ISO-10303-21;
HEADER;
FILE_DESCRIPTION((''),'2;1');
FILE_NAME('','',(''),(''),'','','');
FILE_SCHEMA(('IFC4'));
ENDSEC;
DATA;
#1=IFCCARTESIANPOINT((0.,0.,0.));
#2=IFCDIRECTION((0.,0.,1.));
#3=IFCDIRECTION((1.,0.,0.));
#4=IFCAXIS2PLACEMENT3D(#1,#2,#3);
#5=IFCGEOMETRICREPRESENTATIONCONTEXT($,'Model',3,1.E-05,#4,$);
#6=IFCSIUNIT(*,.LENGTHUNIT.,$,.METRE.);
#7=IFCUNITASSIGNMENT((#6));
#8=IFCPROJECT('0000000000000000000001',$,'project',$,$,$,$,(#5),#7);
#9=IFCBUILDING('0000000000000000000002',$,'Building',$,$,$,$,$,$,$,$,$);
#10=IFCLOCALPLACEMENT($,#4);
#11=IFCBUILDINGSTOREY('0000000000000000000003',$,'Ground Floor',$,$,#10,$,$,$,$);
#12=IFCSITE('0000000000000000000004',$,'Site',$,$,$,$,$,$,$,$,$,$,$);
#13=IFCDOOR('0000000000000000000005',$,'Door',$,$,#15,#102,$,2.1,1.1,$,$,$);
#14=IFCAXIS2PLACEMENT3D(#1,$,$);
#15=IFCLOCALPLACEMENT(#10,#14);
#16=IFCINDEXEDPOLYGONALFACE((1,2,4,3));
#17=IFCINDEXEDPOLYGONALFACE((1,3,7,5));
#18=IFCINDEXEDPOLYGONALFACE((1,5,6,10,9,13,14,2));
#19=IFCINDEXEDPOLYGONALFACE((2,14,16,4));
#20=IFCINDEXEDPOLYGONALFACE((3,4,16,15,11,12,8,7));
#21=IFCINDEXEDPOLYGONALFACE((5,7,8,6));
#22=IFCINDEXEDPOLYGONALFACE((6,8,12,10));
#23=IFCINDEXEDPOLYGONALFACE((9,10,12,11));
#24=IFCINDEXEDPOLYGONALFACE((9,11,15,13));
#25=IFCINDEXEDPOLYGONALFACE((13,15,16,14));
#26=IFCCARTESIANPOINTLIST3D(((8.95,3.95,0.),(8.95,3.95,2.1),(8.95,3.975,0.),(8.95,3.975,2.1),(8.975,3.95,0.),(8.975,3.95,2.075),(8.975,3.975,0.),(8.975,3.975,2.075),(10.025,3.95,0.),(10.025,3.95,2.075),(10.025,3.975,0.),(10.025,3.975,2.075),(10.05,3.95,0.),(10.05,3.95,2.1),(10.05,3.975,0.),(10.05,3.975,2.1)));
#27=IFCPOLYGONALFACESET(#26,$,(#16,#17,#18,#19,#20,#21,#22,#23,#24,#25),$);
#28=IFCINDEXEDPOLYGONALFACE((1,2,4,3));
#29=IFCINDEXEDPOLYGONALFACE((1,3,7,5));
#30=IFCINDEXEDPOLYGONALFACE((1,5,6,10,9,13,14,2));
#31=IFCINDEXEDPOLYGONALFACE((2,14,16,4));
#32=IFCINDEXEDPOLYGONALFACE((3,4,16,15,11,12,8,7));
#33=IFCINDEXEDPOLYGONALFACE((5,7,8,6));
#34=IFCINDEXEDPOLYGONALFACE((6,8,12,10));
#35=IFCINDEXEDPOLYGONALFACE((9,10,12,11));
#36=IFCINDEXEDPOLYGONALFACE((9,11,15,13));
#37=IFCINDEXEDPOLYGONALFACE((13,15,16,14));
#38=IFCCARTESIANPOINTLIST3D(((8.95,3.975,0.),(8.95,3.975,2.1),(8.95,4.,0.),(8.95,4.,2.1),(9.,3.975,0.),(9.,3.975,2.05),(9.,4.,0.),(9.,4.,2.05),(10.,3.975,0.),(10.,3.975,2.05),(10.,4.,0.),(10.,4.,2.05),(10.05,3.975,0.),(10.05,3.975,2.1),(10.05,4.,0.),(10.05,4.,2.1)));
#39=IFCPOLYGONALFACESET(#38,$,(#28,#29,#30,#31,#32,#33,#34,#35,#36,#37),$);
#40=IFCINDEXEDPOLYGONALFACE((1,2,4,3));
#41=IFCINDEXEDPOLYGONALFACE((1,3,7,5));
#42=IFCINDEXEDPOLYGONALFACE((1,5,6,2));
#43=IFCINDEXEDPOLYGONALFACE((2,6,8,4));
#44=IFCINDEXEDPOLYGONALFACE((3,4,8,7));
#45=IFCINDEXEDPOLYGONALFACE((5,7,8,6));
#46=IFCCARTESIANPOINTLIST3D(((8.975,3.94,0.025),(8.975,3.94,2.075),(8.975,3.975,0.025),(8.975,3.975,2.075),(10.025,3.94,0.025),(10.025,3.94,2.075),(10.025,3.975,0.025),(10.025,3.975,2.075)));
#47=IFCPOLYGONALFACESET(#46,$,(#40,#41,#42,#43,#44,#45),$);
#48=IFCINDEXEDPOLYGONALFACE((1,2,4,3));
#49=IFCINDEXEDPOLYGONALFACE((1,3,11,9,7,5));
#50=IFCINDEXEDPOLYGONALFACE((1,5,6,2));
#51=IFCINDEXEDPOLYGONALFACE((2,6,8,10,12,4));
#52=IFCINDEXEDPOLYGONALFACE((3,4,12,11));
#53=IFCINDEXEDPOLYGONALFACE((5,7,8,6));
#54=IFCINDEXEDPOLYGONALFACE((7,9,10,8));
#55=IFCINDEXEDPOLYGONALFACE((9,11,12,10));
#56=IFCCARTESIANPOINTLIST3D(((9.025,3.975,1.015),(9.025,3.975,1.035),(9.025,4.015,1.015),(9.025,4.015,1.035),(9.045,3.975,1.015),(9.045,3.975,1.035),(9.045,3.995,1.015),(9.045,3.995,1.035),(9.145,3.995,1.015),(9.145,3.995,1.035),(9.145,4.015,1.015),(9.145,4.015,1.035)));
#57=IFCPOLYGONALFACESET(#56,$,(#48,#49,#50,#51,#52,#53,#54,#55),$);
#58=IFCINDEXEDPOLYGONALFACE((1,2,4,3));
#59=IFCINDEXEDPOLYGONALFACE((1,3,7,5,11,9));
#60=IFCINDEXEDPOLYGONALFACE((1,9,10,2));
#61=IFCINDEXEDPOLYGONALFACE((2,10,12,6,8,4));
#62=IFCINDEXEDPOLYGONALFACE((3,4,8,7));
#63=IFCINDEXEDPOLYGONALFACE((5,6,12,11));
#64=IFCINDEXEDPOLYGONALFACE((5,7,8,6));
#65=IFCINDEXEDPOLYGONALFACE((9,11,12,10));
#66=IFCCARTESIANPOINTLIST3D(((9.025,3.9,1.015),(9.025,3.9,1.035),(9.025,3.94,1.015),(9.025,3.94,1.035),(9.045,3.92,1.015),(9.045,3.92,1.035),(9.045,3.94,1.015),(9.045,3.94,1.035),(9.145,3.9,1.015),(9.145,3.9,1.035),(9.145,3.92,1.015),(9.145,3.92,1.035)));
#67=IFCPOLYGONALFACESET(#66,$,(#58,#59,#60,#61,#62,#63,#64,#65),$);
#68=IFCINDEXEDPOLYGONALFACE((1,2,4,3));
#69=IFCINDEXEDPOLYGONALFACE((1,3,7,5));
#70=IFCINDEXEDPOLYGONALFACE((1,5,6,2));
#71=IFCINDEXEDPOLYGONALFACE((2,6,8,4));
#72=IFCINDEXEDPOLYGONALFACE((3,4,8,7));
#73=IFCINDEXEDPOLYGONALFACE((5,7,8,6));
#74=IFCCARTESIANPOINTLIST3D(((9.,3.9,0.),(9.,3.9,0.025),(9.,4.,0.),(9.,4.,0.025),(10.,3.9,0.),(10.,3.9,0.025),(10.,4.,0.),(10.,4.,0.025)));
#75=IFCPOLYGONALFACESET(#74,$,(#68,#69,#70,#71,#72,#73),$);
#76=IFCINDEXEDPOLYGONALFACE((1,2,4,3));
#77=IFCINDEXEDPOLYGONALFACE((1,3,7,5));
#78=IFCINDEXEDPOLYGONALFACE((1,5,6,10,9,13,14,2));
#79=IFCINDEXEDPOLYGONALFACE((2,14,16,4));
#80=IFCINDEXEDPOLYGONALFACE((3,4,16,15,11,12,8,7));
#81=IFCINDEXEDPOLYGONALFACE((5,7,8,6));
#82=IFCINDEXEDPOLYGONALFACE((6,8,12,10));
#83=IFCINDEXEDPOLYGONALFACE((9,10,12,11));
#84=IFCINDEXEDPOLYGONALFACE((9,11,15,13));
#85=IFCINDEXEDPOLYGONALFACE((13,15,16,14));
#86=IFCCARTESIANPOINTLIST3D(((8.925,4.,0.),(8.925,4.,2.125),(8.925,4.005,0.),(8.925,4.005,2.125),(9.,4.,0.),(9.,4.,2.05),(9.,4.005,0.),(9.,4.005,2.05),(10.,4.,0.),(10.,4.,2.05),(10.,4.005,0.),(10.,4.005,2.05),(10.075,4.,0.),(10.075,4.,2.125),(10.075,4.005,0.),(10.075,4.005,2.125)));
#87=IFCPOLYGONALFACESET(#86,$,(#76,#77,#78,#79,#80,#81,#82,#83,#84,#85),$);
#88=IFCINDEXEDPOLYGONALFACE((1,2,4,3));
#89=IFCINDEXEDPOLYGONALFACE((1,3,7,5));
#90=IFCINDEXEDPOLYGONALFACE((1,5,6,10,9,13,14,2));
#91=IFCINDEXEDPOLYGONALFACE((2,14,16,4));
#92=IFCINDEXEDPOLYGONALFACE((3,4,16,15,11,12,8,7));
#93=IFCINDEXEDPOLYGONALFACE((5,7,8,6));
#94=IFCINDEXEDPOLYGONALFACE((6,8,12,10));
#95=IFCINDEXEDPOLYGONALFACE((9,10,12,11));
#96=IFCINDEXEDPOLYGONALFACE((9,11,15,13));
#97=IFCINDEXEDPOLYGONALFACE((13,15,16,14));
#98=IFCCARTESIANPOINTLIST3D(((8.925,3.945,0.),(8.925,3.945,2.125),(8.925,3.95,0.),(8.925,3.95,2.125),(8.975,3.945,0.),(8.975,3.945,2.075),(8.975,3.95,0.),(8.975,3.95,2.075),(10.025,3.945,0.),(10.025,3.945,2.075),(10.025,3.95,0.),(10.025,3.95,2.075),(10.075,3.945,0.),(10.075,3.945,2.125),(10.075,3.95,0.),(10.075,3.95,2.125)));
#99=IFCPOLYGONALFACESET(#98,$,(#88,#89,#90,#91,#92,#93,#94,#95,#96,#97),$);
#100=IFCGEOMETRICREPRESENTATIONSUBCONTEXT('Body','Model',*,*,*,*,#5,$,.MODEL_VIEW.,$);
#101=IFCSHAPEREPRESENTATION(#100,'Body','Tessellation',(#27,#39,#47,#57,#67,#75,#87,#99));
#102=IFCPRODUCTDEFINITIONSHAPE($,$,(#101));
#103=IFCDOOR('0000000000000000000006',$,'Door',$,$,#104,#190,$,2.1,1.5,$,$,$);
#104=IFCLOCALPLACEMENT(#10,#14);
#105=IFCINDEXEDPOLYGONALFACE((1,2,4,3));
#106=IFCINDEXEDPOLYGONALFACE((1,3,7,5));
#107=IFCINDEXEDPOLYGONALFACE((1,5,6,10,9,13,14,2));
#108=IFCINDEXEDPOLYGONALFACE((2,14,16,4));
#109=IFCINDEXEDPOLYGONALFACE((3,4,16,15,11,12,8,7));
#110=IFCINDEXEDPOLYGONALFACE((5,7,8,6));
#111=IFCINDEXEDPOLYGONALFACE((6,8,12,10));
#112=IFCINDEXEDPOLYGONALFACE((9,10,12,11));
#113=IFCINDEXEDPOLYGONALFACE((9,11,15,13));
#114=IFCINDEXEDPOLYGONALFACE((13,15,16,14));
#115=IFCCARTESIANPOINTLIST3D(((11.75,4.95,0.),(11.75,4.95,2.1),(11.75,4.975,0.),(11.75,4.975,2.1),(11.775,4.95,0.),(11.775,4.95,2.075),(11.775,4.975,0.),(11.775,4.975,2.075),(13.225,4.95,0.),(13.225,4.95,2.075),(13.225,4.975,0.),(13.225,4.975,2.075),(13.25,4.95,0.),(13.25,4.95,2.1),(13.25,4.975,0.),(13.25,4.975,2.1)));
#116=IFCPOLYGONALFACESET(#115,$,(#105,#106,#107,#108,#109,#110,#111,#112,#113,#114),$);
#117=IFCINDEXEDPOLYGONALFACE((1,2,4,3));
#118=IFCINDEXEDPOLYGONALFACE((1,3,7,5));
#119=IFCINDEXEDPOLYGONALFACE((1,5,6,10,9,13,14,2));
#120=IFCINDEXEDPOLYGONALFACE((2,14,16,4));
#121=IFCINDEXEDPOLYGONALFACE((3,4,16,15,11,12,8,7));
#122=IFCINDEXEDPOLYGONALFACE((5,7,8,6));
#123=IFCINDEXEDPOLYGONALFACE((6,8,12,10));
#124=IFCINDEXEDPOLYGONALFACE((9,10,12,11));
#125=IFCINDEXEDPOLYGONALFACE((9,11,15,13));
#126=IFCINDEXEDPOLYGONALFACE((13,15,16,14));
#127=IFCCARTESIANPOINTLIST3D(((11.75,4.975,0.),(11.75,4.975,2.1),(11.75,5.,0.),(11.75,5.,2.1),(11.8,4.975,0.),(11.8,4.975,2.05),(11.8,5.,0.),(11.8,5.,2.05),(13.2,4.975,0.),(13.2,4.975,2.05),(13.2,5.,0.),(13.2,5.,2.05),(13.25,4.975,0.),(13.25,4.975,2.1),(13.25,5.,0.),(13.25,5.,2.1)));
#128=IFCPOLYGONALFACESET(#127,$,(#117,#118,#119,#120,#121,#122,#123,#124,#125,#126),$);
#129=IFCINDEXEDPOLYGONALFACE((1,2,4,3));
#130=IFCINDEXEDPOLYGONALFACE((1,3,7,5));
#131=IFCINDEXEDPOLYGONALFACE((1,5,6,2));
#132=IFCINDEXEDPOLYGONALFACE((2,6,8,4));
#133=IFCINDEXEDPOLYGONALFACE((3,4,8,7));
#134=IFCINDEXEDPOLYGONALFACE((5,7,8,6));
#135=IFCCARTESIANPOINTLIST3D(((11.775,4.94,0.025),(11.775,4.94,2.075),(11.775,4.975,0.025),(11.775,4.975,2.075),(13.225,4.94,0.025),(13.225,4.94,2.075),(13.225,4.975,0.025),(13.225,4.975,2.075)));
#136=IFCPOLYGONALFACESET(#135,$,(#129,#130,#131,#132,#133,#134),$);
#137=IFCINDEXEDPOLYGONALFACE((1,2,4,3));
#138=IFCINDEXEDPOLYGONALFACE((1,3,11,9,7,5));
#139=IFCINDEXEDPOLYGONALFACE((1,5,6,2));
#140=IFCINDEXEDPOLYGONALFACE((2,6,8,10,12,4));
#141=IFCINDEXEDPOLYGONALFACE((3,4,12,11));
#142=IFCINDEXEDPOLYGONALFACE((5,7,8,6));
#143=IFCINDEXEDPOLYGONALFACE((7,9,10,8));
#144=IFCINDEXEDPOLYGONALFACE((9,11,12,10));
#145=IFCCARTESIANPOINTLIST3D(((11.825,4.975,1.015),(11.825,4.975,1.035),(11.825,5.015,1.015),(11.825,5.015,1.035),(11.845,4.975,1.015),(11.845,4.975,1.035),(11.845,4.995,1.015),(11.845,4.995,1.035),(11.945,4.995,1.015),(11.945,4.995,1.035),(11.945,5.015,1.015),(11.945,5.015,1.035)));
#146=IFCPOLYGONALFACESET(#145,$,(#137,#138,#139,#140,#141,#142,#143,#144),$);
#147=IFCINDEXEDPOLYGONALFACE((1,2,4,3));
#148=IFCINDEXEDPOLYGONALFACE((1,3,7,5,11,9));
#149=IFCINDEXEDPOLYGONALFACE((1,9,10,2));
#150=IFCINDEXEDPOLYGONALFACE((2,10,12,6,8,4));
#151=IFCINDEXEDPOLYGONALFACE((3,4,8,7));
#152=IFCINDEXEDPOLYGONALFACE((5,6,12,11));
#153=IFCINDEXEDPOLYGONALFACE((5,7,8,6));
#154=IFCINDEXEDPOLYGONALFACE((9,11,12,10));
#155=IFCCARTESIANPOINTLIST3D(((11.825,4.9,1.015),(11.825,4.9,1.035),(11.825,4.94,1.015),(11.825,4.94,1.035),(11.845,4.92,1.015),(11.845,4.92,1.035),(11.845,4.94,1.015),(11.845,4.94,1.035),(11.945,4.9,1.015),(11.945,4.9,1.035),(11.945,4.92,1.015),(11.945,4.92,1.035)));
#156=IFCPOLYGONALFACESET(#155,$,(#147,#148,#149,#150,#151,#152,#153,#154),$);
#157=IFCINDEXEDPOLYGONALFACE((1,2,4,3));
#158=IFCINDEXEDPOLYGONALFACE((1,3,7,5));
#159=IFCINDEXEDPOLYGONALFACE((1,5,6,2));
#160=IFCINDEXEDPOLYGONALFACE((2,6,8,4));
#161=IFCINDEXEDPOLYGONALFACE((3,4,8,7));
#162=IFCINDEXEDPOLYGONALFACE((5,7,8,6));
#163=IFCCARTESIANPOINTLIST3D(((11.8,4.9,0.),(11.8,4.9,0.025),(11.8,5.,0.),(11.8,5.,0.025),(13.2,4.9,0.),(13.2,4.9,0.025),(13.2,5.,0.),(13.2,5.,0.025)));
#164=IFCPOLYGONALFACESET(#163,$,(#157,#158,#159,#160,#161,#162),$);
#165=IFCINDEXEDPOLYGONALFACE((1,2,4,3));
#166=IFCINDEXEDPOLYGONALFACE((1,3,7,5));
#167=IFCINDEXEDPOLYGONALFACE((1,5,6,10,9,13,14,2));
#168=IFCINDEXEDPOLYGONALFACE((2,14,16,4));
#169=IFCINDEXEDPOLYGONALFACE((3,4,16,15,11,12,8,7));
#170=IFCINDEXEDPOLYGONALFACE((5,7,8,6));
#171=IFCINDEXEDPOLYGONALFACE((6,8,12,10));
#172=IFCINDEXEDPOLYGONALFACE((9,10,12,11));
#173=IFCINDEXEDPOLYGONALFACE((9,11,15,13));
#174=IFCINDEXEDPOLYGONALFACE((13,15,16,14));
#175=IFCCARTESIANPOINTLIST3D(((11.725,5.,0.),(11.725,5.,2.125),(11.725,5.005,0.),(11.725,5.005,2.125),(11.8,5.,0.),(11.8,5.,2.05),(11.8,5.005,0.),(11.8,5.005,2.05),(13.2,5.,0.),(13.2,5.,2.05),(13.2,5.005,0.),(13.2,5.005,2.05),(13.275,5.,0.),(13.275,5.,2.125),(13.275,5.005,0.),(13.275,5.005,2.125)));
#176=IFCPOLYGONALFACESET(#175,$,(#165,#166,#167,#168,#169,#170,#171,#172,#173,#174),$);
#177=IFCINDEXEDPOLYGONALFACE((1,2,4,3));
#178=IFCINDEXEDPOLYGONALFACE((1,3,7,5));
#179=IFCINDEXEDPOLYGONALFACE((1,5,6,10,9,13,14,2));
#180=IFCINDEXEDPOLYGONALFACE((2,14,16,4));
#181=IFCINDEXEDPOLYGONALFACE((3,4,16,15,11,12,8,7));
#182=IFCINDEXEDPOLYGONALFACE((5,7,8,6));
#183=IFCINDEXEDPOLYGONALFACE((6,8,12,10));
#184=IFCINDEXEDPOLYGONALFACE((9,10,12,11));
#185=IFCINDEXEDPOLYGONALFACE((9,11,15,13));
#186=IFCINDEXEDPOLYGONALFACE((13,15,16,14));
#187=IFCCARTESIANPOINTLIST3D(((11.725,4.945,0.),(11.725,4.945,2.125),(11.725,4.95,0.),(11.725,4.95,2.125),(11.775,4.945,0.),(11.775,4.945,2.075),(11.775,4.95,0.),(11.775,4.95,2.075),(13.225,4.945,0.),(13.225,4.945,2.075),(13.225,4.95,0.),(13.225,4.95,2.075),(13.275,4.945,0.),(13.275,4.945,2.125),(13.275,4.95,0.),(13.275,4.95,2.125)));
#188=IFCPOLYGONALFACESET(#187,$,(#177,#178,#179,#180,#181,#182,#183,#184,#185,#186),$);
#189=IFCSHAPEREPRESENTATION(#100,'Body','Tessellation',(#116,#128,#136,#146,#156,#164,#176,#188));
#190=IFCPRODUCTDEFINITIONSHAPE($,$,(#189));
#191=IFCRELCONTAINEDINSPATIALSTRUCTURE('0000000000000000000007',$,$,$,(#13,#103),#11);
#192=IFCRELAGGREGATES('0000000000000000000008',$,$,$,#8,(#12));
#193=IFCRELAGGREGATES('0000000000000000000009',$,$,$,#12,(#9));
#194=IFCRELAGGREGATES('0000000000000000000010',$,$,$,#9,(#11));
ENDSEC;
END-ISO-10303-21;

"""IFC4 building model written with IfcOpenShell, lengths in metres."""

from ifc_helpers import new_model, si_unit, frame, origin_with_axes, place, context, subcontext, project, spatial, line, indexed_curve, outline, extrude, element, save


model = new_model("IFC4")

# Units and contexts
model_context = context("Model", 3, precision=1e-05, world=origin_with_axes())
body_context = subcontext(model_context, "Body", "Model", "MODEL_VIEW")
ifc_project = project(units=[si_unit("LENGTHUNIT", "METRE")], contexts=[model_context])

# Site, building, storey
site = spatial("IfcSite", under=ifc_project, Name="Site")
building = spatial("IfcBuilding", under=site, Name="Building")
storey_placement = place(None, origin_with_axes())
storey = spatial("IfcBuildingStorey", under=building, at=storey_placement, Name="Ground Floor")

# Doors
door_1_placement = place(storey_placement, frame((10.05, 4.0, 0.0), z_axis=(0.0, 0.0, 1.0), x_axis=(-1.0, 0.0, 0.0)))
element("IfcDoor", 1, at=door_1_placement, inside=storey, Name="Door", OverallHeight=2.1, OverallWidth=1.1, context=body_context, shape_type="SweptSolid", body=[
    extrude(outline(indexed_curve([(0.0, 0.0), (0.0, 2.1), (1.1, 2.1), (1.1, 0.0), (1.075, 0.0), (1.075, 2.075), (0.025, 2.075), (0.025, 0.0)], segments=[line(1, 2, 3, 4, 5, 6, 7, 8, 1)])), frame((0.0, 0.025, 0.0), z_axis=(0.0, -1.0, 0.0), x_axis=(1.0, 0.0, 0.0)), (0.0, 0.0, -1.0), 0.025),
    extrude(outline(indexed_curve([(0.0, 0.0), (0.0, 2.1), (1.1, 2.1), (1.1, 0.0), (1.05, 0.0), (1.05, 2.05), (0.05, 2.05), (0.05, 0.0)], segments=[line(1, 2, 3, 4, 5, 6, 7, 8, 1)])), frame((0.0, 0.0, 0.0), z_axis=(0.0, -1.0, 0.0), x_axis=(1.0, 0.0, 0.0)), (0.0, 0.0, -1.0), 0.025),
    extrude(outline(indexed_curve([(0.0, 0.0), (1.05, 0.0), (1.05, 0.035), (0.0, 0.035)], segments=[line(1, 2, 3, 4, 1)])), frame((0.025, 0.025, 0.025), z_axis=(0.0, 0.0, 1.0), x_axis=(1.0, 0.0, 0.0)), (0.0, 0.0, 1.0), 2.05),
    extrude(outline(indexed_curve([(0.0, 0.0), (0.0, -0.04), (-0.12, -0.04), (-0.12, -0.02), (-0.02, -0.02), (-0.02, 0.0)], segments=[line(1, 2, 3, 4, 5, 6, 1)])), frame((1.025, 0.025, 1.015), z_axis=(0.0, 0.0, 1.0), x_axis=(1.0, 0.0, 0.0)), (0.0, 0.0, 1.0), 0.02),
    extrude(outline(indexed_curve([(0.0, 0.0), (0.0, 0.04), (-0.12, 0.04), (-0.12, 0.02), (-0.02, 0.02), (-0.02, 0.0)], segments=[line(1, 2, 3, 4, 5, 6, 1)])), frame((1.025, 0.06, 1.015), z_axis=(0.0, 0.0, 1.0), x_axis=(1.0, 0.0, 0.0)), (0.0, 0.0, 1.0), 0.02),
    extrude(outline(indexed_curve([(0.0, 0.0), (1.0, 0.0), (1.0, 0.1), (0.0, 0.1)], segments=[line(1, 2, 3, 4, 1)])), frame((0.05, 0.0, 0.0), z_axis=(0.0, 0.0, 1.0), x_axis=(1.0, 0.0, 0.0)), (0.0, 0.0, 1.0), 0.025),
    extrude(outline(indexed_curve([(0.0, 0.0), (0.0, 2.125), (1.15, 2.125), (1.15, 0.0), (1.075, 0.0), (1.075, 2.05), (0.075, 2.05), (0.075, 0.0)], segments=[line(1, 2, 3, 4, 5, 6, 7, 8, 1)])), frame((-0.025, -0.005, 0.0), z_axis=(0.0, -1.0, 0.0), x_axis=(1.0, 0.0, 0.0)), (0.0, 0.0, -1.0), 0.005),
    extrude(outline(indexed_curve([(0.0, 0.0), (0.0, 2.125), (1.15, 2.125), (1.15, 0.0), (1.1, 0.0), (1.1, 2.075), (0.05, 2.075), (0.05, 0.0)], segments=[line(1, 2, 3, 4, 5, 6, 7, 8, 1)])), frame((-0.025, 0.05, 0.0), z_axis=(0.0, -1.0, 0.0), x_axis=(1.0, 0.0, 0.0)), (0.0, 0.0, -1.0), 0.005),
])
door_2_placement = place(storey_placement, frame((13.25, 5.0, 0.0), z_axis=(0.0, 0.0, 1.0), x_axis=(-1.0, 0.0, 0.0)))
element("IfcDoor", 2, at=door_2_placement, inside=storey, Name="Door", OverallHeight=2.1, OverallWidth=1.5, context=body_context, shape_type="SweptSolid", body=[
    extrude(outline(indexed_curve([(0.0, 0.0), (0.0, 2.1), (1.5, 2.1), (1.5, 0.0), (1.475, 0.0), (1.475, 2.075), (0.025, 2.075), (0.025, 0.0)], segments=[line(1, 2, 3, 4, 5, 6, 7, 8, 1)])), frame((0.0, 0.025, 0.0), z_axis=(0.0, -1.0, 0.0), x_axis=(1.0, 0.0, 0.0)), (0.0, 0.0, -1.0), 0.025),
    extrude(outline(indexed_curve([(0.0, 0.0), (0.0, 2.1), (1.5, 2.1), (1.5, 0.0), (1.45, 0.0), (1.45, 2.05), (0.05, 2.05), (0.05, 0.0)], segments=[line(1, 2, 3, 4, 5, 6, 7, 8, 1)])), frame((0.0, 0.0, 0.0), z_axis=(0.0, -1.0, 0.0), x_axis=(1.0, 0.0, 0.0)), (0.0, 0.0, -1.0), 0.025),
    extrude(outline(indexed_curve([(0.0, 0.0), (1.45, 0.0), (1.45, 0.035), (0.0, 0.035)], segments=[line(1, 2, 3, 4, 1)])), frame((0.025, 0.025, 0.025), z_axis=(0.0, 0.0, 1.0), x_axis=(1.0, 0.0, 0.0)), (0.0, 0.0, 1.0), 2.05),
    extrude(outline(indexed_curve([(0.0, 0.0), (0.0, -0.04), (-0.12, -0.04), (-0.12, -0.02), (-0.02, -0.02), (-0.02, 0.0)], segments=[line(1, 2, 3, 4, 5, 6, 1)])), frame((1.425, 0.025, 1.015), z_axis=(0.0, 0.0, 1.0), x_axis=(1.0, 0.0, 0.0)), (0.0, 0.0, 1.0), 0.02),
    extrude(outline(indexed_curve([(0.0, 0.0), (0.0, 0.04), (-0.12, 0.04), (-0.12, 0.02), (-0.02, 0.02), (-0.02, 0.0)], segments=[line(1, 2, 3, 4, 5, 6, 1)])), frame((1.425, 0.06, 1.015), z_axis=(0.0, 0.0, 1.0), x_axis=(1.0, 0.0, 0.0)), (0.0, 0.0, 1.0), 0.02),
    extrude(outline(indexed_curve([(0.0, 0.0), (1.4, 0.0), (1.4, 0.1), (0.0, 0.1)], segments=[line(1, 2, 3, 4, 1)])), frame((0.05, 0.0, 0.0), z_axis=(0.0, 0.0, 1.0), x_axis=(1.0, 0.0, 0.0)), (0.0, 0.0, 1.0), 0.025),
    extrude(outline(indexed_curve([(0.0, 0.0), (0.0, 2.125), (1.55, 2.125), (1.55, 0.0), (1.475, 0.0), (1.475, 2.05), (0.075, 2.05), (0.075, 0.0)], segments=[line(1, 2, 3, 4, 5, 6, 7, 8, 1)])), frame((-0.025, -0.005, 0.0), z_axis=(0.0, -1.0, 0.0), x_axis=(1.0, 0.0, 0.0)), (0.0, 0.0, -1.0), 0.005),
    extrude(outline(indexed_curve([(0.0, 0.0), (0.0, 2.125), (1.55, 2.125), (1.55, 0.0), (1.5, 0.0), (1.5, 2.075), (0.05, 2.075), (0.05, 0.0)], segments=[line(1, 2, 3, 4, 5, 6, 7, 8, 1)])), frame((-0.025, 0.05, 0.0), z_axis=(0.0, -1.0, 0.0), x_axis=(1.0, 0.0, 0.0)), (0.0, 0.0, -1.0), 0.005),
])

save(model, "model.ifc")
